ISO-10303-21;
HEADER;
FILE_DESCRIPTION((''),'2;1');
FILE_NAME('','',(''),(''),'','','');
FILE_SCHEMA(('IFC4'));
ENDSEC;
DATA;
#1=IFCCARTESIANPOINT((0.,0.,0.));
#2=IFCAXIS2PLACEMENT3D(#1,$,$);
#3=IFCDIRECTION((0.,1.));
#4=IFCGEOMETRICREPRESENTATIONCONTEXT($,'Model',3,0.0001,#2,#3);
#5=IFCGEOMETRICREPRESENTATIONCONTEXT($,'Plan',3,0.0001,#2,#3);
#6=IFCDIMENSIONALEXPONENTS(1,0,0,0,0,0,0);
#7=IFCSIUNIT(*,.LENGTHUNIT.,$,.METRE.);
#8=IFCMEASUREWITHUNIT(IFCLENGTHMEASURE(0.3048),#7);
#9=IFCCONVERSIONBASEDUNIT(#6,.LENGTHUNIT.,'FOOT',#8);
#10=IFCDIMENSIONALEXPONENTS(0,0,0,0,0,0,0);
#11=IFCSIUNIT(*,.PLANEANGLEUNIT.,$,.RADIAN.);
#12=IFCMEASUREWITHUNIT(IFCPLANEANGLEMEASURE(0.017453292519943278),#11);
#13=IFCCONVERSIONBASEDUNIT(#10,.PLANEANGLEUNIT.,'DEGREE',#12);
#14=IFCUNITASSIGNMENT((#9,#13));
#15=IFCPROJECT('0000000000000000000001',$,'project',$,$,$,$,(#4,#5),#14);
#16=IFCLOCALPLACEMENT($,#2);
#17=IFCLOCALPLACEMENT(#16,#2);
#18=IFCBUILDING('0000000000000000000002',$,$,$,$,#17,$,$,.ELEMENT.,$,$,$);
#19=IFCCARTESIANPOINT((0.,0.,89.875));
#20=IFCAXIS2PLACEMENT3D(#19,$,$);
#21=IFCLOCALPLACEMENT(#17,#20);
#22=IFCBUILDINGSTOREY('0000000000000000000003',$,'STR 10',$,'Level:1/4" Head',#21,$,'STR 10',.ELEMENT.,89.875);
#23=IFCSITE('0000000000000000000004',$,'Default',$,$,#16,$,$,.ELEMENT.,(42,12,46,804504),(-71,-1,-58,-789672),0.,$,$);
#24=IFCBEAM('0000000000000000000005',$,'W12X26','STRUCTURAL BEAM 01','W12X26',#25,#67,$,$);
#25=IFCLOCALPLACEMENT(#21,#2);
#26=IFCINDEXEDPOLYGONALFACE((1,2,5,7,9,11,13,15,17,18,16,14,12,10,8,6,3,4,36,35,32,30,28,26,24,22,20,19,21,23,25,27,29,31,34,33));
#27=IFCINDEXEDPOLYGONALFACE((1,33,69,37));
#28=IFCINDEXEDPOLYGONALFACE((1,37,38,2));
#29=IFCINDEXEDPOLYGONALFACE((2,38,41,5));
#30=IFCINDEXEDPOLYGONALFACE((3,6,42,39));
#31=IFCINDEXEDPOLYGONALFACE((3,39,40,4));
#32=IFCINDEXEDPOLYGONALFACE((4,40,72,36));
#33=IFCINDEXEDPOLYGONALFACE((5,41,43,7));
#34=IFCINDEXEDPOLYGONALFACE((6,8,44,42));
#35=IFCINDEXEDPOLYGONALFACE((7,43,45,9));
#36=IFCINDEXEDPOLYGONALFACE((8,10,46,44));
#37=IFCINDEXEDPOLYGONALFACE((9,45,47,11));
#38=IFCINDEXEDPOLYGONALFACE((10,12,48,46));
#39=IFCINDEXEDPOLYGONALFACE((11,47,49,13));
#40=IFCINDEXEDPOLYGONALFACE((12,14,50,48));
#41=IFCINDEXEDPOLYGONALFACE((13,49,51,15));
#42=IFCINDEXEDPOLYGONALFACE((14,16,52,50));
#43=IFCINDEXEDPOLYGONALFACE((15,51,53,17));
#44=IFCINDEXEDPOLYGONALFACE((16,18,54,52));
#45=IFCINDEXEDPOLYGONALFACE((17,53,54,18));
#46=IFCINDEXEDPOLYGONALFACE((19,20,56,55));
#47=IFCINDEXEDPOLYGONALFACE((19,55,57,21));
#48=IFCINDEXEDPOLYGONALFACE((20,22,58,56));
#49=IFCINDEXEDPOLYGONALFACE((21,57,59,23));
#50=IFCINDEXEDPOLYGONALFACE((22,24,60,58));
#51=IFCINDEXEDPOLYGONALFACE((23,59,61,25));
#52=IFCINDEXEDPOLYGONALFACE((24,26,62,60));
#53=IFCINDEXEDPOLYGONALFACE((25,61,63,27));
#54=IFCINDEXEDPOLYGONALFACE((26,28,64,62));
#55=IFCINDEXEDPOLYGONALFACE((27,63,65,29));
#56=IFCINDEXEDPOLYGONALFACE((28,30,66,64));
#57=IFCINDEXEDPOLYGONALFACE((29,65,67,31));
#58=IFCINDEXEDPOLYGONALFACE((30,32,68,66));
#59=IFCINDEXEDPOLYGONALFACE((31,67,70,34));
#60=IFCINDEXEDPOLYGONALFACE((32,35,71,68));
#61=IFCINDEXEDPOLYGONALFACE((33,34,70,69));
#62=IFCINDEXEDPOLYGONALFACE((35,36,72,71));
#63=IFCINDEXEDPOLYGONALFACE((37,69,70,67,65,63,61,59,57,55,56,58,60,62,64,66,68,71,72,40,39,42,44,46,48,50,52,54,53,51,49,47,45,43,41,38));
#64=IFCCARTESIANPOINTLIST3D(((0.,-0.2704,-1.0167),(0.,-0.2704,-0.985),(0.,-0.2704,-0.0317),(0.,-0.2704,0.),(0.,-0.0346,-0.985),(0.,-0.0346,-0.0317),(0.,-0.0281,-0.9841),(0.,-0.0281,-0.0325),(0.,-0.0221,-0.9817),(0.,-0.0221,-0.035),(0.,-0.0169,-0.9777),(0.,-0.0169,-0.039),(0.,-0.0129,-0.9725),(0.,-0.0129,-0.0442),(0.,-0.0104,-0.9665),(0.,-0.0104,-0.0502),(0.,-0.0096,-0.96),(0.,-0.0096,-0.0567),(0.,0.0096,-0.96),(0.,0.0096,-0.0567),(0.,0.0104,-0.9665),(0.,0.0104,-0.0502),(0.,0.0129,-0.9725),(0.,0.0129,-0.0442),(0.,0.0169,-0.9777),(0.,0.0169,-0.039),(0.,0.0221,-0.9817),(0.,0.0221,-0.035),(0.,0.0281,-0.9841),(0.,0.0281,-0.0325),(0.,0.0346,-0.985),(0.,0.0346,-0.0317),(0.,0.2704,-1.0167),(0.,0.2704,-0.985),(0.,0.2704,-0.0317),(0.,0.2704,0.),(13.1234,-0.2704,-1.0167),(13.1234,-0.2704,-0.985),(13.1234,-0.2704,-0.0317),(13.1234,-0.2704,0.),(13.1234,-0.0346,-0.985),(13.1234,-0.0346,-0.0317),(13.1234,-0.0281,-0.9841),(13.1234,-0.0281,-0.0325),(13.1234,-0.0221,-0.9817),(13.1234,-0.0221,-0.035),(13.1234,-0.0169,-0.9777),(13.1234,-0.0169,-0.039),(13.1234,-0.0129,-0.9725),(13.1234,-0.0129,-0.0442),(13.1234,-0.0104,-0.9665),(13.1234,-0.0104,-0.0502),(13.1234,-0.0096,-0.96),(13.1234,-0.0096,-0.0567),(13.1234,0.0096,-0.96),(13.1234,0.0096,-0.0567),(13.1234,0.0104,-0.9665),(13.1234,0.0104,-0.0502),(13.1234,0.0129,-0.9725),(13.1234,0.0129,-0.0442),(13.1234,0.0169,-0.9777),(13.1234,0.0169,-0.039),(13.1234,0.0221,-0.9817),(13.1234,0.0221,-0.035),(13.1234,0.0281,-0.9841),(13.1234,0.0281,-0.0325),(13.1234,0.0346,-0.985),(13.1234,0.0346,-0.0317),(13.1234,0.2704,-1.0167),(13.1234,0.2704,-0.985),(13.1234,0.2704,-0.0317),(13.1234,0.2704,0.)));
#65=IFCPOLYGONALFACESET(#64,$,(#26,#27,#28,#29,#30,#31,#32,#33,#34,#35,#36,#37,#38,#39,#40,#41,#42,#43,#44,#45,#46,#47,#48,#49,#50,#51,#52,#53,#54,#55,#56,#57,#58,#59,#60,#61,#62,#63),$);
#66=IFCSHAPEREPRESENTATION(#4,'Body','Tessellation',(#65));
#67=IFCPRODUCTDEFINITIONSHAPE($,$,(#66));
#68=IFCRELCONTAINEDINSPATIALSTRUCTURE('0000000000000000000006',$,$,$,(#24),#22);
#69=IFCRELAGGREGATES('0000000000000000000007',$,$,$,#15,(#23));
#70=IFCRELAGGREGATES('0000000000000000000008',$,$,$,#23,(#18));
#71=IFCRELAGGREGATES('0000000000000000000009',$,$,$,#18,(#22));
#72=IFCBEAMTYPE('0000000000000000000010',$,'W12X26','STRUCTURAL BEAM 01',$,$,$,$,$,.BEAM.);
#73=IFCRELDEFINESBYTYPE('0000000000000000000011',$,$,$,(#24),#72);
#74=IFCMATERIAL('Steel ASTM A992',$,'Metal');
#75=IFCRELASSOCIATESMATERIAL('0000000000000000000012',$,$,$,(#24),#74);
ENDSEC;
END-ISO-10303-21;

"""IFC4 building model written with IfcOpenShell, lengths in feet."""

from ifc_helpers import new_model, entity, si_unit, converted_unit, direction, frame, origin, origin_2d, place, context, project, spatial, i_section, extrude, material, type_object, element, save


model = new_model("IFC4")

# Units and contexts
model_context = context("Model", 3, precision=0.0001, world=origin(), true_north=direction((0.0, 1.0)))
plan_context = context("Plan", 3, precision=0.0001, world=origin(), true_north=direction((0.0, 1.0)))
ifc_project = project(units=[converted_unit("LENGTHUNIT", "FOOT", entity("IfcLengthMeasure", 0.3048), si_unit("LENGTHUNIT", "METRE"), dimensions=[1, 0, 0, 0, 0, 0, 0]), converted_unit("PLANEANGLEUNIT", "DEGREE", entity("IfcPlaneAngleMeasure", 0.017453292519943278), si_unit("PLANEANGLEUNIT", "RADIAN"), dimensions=[0, 0, 0, 0, 0, 0, 0])], contexts=[model_context, plan_context])

# Site, building, storey
site_placement = place(None, origin())
site = spatial("IfcSite", under=ifc_project, at=site_placement, Name="Default", CompositionType="ELEMENT", RefLatitude=(42, 12, 46, 804504), RefLongitude=(-71, -1, -58, -789672), RefElevation=0.0)
building_placement = place(site_placement, origin())
building = spatial("IfcBuilding", under=site, at=building_placement, CompositionType="ELEMENT")
storey_placement = place(building_placement, frame((0.0, 0.0, 89.875)))
storey = spatial("IfcBuildingStorey", under=building, at=storey_placement, Name="STR 10", ObjectType="Level:1/4\" Head", LongName="STR 10", CompositionType="ELEMENT", Elevation=89.875)

# Beam
ifc_material = material(Name="Steel ASTM A992", Category="Metal")
beam_type_1 = type_object("IfcBeamType", Name="W12X26", Description="STRUCTURAL BEAM 01", PredefinedType="BEAM")
beam_1_placement = place(storey_placement, frame((0.0, 0.0, -0.5083), z_axis=(-1.0, 0.0, 0.0), x_axis=(0.0, -1.0, 0.0)))
element("IfcBeam", 1, at=beam_1_placement, inside=storey, type_object=beam_type_1, material=ifc_material, Name="W12X26", Description="STRUCTURAL BEAM 01", ObjectType="W12X26", context=model_context, shape_type="SweptSolid", body=[
    extrude(i_section(OverallWidth=0.5408, OverallDepth=1.0167, WebThickness=0.0192, FlangeThickness=0.0317, FilletRadius=0.025, at=origin_2d()), origin(), (0.0, 0.0, -1.0), 13.1234),
])

save(model, "model.ifc")
